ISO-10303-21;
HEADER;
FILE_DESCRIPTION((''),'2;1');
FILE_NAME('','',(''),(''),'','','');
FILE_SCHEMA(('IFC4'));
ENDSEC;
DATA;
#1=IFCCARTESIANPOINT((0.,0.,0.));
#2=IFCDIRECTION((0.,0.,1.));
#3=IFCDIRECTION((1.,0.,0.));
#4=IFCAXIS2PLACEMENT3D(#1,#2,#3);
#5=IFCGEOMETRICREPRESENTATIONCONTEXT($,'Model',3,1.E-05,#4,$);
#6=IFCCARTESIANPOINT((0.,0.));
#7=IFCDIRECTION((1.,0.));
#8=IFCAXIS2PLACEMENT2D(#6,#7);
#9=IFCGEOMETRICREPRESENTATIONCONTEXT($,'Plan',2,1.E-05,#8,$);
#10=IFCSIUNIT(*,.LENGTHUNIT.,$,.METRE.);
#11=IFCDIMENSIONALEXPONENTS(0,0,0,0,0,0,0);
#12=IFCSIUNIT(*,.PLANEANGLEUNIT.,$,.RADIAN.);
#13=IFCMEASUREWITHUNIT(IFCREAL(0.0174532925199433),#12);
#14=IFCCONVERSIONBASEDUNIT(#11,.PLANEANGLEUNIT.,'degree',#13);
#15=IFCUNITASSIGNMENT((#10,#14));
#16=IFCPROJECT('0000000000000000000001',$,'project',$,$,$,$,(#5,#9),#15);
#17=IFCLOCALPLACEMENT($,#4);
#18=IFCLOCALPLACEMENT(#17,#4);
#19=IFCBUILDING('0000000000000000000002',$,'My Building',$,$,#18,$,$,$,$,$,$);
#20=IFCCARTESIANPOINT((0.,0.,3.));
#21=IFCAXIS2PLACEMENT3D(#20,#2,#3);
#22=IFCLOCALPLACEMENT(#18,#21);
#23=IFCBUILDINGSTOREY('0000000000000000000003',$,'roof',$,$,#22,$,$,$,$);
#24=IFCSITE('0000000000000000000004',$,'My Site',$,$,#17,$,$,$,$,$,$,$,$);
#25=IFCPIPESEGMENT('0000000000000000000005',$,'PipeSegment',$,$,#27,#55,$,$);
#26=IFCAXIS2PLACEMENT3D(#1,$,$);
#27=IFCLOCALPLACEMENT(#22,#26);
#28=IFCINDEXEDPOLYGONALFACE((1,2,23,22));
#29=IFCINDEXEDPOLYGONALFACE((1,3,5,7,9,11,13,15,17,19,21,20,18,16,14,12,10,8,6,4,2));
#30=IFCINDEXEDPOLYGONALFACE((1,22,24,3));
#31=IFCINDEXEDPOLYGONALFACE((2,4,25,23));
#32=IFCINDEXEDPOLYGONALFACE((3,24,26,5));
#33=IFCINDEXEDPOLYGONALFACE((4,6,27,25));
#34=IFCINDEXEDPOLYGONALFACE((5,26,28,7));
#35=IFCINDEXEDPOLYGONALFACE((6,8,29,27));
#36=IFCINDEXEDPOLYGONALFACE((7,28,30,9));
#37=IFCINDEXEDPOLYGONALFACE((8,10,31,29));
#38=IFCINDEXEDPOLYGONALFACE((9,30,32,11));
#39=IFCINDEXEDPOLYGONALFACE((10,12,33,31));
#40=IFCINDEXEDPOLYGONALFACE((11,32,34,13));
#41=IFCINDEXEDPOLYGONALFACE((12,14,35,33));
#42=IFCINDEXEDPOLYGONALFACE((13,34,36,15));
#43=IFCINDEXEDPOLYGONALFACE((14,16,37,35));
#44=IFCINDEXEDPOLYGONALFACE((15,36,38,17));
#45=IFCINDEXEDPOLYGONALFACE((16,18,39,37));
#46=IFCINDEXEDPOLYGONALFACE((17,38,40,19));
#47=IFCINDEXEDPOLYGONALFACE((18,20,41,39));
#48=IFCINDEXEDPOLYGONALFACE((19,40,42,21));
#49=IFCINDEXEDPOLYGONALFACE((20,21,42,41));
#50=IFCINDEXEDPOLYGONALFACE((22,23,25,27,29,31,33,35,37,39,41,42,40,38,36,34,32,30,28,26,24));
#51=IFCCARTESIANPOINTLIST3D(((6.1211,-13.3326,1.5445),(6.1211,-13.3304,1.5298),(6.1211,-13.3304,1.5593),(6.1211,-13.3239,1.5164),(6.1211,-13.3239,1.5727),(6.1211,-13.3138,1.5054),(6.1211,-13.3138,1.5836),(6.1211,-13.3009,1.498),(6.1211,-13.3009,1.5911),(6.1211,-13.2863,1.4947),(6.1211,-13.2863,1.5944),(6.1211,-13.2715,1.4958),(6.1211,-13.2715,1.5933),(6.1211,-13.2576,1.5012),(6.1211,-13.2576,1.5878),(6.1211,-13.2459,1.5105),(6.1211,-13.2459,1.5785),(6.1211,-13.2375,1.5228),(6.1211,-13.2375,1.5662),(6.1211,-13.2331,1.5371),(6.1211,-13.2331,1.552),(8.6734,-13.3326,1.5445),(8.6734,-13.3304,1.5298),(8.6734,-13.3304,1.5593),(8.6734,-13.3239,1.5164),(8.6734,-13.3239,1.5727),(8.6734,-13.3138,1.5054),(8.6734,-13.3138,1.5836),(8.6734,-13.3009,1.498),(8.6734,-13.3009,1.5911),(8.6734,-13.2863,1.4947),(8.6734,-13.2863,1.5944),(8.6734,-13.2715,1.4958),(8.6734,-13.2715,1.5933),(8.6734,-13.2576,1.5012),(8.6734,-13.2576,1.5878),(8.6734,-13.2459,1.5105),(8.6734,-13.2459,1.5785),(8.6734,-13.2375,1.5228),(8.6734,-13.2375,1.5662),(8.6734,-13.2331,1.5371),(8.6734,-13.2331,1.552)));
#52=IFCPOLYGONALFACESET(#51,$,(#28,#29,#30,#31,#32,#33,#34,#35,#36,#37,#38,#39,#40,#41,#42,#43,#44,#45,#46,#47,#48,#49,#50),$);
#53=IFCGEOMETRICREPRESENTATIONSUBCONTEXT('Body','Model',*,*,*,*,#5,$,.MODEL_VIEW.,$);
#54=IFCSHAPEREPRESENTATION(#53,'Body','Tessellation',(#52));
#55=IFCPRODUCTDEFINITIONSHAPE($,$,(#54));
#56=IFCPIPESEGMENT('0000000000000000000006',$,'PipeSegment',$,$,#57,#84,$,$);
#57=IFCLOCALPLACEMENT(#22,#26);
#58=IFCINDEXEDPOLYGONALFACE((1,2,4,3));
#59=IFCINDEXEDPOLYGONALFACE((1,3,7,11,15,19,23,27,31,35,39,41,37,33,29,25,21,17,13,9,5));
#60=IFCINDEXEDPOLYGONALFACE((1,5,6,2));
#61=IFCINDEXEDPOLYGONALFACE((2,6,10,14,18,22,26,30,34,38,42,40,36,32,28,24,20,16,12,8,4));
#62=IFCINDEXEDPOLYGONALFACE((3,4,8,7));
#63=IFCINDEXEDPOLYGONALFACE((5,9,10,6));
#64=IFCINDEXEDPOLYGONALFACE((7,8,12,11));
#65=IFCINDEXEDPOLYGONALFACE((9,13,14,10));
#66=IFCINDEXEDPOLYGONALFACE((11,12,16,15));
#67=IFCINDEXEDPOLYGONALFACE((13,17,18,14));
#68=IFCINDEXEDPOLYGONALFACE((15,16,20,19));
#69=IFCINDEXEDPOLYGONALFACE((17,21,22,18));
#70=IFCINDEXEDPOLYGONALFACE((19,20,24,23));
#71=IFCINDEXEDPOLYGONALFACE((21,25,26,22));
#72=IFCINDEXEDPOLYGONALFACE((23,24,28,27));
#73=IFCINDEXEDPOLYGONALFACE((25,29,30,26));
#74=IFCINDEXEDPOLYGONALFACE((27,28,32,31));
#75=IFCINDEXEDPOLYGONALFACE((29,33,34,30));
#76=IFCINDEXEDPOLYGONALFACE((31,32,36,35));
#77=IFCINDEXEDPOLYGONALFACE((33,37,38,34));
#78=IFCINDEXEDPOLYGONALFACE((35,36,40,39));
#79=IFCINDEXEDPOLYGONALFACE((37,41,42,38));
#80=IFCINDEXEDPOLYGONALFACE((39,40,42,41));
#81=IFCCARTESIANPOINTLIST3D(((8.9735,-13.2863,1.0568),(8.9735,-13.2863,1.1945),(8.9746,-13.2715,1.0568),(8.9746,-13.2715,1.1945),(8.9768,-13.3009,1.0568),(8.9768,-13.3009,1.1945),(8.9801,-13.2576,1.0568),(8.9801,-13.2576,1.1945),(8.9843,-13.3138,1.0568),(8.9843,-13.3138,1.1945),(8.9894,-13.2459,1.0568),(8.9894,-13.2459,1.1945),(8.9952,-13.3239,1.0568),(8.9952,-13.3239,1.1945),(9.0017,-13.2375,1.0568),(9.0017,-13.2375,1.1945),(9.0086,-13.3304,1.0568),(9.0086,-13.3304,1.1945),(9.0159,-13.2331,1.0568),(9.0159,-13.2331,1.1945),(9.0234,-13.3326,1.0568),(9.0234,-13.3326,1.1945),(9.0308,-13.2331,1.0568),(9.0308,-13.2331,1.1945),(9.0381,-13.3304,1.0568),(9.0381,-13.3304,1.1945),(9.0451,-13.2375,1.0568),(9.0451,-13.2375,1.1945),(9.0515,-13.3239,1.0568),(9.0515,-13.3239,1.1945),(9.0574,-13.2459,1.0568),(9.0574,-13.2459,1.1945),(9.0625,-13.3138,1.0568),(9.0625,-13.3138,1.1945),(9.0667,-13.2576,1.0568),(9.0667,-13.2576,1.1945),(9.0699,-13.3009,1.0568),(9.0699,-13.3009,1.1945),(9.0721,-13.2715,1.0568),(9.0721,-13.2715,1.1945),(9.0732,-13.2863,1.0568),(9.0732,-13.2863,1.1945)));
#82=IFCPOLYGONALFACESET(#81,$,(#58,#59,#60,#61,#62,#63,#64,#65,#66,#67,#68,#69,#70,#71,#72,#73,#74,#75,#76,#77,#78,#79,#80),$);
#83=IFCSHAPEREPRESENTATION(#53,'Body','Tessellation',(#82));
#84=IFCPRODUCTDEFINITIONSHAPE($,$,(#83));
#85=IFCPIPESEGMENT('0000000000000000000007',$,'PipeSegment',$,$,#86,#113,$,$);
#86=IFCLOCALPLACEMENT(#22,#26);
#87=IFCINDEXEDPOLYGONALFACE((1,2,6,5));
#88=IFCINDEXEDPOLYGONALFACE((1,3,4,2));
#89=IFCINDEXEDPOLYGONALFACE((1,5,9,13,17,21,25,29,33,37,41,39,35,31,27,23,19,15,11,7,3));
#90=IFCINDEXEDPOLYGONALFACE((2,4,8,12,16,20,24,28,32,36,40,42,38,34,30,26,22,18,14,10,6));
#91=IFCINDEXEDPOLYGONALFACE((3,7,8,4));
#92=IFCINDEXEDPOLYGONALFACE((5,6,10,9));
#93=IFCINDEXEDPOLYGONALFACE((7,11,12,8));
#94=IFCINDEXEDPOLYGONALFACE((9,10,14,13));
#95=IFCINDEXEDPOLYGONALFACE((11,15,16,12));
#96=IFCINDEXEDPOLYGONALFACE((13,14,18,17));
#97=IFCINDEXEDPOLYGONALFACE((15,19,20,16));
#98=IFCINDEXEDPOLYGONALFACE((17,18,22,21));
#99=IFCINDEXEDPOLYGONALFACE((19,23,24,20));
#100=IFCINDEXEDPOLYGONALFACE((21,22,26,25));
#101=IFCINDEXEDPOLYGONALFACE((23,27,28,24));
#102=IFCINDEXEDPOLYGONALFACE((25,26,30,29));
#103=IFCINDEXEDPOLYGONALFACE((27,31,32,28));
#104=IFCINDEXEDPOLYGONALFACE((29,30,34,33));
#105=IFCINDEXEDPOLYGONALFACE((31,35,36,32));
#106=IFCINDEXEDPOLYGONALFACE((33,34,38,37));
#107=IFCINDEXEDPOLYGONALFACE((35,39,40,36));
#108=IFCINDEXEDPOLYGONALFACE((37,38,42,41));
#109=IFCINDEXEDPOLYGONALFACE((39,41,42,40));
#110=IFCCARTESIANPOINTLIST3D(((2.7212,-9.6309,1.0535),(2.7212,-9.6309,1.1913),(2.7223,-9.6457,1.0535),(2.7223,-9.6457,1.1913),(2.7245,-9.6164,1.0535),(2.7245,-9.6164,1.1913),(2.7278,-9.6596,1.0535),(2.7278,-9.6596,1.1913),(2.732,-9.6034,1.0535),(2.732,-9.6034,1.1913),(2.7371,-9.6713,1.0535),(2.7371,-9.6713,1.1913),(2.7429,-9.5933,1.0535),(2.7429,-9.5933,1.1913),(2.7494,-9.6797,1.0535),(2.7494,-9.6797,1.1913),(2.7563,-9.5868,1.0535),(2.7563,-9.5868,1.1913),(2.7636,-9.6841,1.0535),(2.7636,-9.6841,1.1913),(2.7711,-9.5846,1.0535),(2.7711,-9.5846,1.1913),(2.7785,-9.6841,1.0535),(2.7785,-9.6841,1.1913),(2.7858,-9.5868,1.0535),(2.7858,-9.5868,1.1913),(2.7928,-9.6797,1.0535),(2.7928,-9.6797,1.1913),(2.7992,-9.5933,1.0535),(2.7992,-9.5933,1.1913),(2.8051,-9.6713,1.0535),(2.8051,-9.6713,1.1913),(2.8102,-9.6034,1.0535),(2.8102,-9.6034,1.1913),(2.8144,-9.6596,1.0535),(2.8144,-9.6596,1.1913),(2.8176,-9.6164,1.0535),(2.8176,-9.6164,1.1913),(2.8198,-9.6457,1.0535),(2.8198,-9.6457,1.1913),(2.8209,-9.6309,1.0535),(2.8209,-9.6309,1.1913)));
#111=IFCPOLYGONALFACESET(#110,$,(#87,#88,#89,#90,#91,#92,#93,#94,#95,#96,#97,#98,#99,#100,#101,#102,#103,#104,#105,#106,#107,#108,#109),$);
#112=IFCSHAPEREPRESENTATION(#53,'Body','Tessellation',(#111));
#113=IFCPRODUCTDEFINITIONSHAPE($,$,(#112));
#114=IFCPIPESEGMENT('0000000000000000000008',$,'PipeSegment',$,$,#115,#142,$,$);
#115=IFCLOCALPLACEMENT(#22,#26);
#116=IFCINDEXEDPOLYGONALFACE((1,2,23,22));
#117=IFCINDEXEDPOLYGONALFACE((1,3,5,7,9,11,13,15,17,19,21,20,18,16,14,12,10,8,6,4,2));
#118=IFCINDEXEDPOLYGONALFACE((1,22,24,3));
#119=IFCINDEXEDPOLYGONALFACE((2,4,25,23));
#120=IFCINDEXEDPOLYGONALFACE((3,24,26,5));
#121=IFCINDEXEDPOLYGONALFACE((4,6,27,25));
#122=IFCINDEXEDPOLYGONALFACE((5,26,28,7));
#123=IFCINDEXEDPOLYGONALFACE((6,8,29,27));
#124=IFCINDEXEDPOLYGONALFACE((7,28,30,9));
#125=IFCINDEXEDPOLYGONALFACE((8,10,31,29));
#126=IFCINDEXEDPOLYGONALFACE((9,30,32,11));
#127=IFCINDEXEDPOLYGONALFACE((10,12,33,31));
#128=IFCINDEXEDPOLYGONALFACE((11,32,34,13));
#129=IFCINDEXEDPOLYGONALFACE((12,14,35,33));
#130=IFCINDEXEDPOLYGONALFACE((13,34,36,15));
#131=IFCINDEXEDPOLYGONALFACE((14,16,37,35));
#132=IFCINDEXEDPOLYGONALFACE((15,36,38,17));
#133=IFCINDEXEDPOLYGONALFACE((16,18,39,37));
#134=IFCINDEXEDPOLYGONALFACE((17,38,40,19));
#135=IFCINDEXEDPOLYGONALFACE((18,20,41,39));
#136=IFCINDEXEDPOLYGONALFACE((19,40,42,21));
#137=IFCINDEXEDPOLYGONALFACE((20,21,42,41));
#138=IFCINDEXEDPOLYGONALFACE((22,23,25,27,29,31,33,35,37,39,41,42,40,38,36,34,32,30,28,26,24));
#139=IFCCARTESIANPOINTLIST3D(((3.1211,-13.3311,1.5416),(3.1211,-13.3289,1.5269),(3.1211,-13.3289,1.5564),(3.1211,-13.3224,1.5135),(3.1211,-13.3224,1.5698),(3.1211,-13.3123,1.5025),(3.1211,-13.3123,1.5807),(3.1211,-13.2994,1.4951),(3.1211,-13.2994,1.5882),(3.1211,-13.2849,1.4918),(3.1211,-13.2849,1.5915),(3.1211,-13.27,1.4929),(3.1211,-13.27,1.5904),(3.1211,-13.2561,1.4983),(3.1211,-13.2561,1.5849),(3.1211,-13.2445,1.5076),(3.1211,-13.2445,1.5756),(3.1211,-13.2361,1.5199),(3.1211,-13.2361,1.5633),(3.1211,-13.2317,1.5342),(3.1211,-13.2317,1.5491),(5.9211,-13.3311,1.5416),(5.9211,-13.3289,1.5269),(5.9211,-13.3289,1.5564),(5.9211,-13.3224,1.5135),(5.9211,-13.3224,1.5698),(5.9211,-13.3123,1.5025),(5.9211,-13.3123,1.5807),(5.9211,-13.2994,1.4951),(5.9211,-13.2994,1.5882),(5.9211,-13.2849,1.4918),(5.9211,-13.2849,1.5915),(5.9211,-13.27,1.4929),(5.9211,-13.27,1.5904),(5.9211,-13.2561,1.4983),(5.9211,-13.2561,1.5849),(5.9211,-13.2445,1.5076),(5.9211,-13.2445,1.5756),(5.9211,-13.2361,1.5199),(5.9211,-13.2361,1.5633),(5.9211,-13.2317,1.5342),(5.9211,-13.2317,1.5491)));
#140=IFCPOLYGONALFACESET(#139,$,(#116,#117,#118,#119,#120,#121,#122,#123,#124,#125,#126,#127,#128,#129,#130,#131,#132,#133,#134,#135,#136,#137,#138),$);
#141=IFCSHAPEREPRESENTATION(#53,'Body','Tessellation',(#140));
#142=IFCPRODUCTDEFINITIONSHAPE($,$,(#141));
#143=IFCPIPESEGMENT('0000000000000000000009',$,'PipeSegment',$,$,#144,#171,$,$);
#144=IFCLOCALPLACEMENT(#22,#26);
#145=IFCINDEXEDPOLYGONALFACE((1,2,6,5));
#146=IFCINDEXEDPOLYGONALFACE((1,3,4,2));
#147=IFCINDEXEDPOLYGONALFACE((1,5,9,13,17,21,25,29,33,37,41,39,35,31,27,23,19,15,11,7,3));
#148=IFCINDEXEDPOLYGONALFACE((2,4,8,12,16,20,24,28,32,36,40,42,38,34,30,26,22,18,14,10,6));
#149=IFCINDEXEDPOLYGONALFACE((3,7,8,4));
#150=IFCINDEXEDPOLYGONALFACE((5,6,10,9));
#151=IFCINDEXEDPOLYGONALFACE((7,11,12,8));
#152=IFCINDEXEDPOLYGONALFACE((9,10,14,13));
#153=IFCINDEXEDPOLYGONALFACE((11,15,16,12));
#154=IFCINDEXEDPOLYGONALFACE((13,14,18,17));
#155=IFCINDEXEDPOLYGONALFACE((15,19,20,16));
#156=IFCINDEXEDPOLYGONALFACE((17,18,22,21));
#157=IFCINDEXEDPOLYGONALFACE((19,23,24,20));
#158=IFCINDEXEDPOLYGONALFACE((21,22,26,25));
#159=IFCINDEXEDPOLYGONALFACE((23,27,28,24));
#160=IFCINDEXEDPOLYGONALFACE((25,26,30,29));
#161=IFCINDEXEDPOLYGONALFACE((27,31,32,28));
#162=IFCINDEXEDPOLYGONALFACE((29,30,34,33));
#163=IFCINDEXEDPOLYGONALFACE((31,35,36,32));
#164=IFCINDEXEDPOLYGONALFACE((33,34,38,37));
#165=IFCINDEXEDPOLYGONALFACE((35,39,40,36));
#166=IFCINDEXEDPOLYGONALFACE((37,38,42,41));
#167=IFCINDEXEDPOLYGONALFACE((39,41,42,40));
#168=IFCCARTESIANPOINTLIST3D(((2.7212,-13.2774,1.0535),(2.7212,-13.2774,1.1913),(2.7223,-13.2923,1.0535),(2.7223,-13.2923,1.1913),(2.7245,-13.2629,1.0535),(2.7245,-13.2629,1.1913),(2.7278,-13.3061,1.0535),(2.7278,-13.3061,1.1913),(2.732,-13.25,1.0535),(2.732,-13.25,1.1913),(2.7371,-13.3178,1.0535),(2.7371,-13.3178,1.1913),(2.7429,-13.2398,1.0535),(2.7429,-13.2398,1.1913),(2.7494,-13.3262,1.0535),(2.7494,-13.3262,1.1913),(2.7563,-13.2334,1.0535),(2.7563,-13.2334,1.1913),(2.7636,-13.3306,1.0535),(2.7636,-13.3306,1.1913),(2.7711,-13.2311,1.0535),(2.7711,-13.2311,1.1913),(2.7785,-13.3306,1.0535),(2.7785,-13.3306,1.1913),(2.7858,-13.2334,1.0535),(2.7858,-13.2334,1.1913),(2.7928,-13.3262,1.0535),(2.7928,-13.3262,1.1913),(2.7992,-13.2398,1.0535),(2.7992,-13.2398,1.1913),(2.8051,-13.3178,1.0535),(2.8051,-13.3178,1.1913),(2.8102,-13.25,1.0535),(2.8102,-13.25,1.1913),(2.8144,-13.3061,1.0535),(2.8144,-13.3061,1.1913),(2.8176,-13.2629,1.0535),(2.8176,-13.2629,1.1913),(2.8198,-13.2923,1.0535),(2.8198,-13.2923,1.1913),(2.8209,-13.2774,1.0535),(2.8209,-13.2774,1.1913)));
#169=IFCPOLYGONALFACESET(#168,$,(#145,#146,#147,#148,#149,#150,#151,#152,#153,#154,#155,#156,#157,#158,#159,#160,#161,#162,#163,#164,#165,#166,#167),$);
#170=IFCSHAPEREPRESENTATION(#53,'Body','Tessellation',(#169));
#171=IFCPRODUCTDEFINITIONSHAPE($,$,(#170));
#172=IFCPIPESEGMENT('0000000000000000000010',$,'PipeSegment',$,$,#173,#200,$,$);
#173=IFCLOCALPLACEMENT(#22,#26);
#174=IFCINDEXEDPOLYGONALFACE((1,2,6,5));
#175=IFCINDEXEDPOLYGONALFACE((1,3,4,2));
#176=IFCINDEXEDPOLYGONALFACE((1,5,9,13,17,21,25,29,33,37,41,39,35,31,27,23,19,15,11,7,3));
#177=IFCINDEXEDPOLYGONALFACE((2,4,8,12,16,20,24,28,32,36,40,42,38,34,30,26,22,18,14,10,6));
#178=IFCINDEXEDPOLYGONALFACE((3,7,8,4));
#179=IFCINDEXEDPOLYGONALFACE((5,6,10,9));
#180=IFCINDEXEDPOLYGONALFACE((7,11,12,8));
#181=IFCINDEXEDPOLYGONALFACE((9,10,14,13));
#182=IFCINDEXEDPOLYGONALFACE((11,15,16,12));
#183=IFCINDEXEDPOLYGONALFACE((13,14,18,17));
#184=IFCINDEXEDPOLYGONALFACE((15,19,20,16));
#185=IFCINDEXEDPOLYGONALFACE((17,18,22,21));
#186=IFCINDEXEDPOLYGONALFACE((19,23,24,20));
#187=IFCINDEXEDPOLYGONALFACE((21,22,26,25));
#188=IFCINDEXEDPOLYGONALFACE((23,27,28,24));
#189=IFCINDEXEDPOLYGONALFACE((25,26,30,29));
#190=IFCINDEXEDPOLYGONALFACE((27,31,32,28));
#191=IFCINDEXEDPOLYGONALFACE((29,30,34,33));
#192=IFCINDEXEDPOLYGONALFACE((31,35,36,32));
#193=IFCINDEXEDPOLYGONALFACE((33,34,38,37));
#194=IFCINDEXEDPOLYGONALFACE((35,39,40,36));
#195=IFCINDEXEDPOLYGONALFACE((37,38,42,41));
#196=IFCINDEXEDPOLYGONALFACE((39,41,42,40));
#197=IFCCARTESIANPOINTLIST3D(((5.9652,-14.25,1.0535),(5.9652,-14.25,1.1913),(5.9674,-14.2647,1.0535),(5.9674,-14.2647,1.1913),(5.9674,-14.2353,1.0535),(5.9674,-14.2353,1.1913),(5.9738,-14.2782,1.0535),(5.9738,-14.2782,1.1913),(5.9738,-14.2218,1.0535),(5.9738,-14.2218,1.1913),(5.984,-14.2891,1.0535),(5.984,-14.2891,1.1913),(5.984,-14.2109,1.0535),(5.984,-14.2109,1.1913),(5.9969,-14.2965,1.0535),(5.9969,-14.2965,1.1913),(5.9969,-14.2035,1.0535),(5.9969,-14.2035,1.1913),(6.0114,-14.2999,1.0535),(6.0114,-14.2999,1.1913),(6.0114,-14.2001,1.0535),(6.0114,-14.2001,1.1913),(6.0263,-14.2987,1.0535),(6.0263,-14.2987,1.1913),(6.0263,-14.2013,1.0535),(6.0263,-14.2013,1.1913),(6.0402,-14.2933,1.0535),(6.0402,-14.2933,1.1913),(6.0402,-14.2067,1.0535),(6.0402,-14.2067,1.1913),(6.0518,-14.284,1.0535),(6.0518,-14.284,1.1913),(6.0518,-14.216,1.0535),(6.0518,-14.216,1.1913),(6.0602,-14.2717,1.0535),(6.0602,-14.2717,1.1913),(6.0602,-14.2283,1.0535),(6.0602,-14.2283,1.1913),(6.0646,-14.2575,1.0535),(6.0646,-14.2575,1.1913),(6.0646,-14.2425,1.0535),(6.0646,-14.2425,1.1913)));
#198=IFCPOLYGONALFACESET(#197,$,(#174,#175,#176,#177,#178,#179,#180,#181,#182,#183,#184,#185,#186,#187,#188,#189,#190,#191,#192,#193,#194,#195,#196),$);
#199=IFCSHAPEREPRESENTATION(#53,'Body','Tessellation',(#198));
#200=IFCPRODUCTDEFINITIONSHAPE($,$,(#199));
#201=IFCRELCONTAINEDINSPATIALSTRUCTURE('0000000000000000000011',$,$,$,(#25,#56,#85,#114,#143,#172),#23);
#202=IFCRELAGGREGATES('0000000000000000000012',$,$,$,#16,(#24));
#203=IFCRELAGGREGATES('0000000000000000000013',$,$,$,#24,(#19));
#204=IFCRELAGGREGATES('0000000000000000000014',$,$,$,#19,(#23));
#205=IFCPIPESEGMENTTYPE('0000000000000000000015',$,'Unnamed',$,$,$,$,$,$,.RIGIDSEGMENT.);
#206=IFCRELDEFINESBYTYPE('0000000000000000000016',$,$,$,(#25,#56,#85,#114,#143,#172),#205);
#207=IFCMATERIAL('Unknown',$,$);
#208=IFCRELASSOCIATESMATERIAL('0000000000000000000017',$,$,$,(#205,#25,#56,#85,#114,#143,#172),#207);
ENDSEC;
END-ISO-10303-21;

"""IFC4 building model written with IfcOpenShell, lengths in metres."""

from ifc_helpers import new_model, entity, si_unit, converted_unit, frame, origin_with_axes, origin_2d_with_axis, place, context, subcontext, project, spatial, circle, extrude, material, material_profile, profile_set, profile_usage, type_object, element, save


model = new_model("IFC4")

# Units and contexts
model_context = context("Model", 3, precision=1e-05, world=origin_with_axes())
plan_context = context("Plan", 2, precision=1e-05, world=origin_2d_with_axis())
body_context_1 = subcontext(model_context, "Body", "Model", "MODEL_VIEW")
ifc_project = project(units=[si_unit("LENGTHUNIT", "METRE"), converted_unit("PLANEANGLEUNIT", "degree", entity("IfcReal", 0.0174532925199433), si_unit("PLANEANGLEUNIT", "RADIAN"), dimensions=[0, 0, 0, 0, 0, 0, 0])], contexts=[model_context, plan_context])

# Site, building, storey
site_placement = place(None, origin_with_axes())
site = spatial("IfcSite", under=ifc_project, at=site_placement, Name="My Site")
building_placement = place(site_placement, origin_with_axes())
building = spatial("IfcBuilding", under=site, at=building_placement, Name="My Building")
storey_placement = place(building_placement, frame((0.0, 0.0, 3.0), z_axis=(0.0, 0.0, 1.0), x_axis=(1.0, 0.0, 0.0)))
storey = spatial("IfcBuildingStorey", under=building, at=storey_placement, Name="roof")

# Shared definitions
ifc_material = material(Name="Unknown")

# Pipe segments
ifc_material_profile_1 = material_profile(ifc_material, circle(Radius=0.05))
ifc_profile_set_1 = profile_set([ifc_material_profile_1])
pipe_segment_type = type_object("IfcPipeSegmentType", Name="Unnamed", PredefinedType="RIGIDSEGMENT", material=ifc_profile_set_1)
ifc_profile_usage_1 = profile_usage(ifc_profile_set_1, cardinal=5)
pipe_segment_1_placement = place(storey_placement, frame((6.1211, -13.2826, 1.5445), z_axis=(1.0, 0.0, 0.0), x_axis=(0.0, -1.0, 0.0)))
element("IfcPipeSegment", 1, at=pipe_segment_1_placement, inside=storey, type_object=pipe_segment_type, material=ifc_profile_usage_1, Name="PipeSegment", context=body_context_1, shape_type="SweptSolid", body=[
    extrude(circle(Radius=0.05), origin_with_axes(), (0.0, 0.0, 1.0), 2.5523),
])
ifc_profile_usage_2 = profile_usage(ifc_profile_set_1, cardinal=5)
pipe_segment_2_placement = place(storey_placement, frame((9.0234, -13.2826, 1.0568), z_axis=(0.000001, -0.000001, 1.0), x_axis=(0.0, -1.0, -0.000001)))
element("IfcPipeSegment", 2, at=pipe_segment_2_placement, inside=storey, type_object=pipe_segment_type, material=ifc_profile_usage_2, Name="PipeSegment", context=body_context_1, shape_type="SweptSolid", body=[
    extrude(circle(Radius=0.05), origin_with_axes(), (0.0, 0.0, 1.0), 0.1377),
])
ifc_profile_usage_3 = profile_usage(ifc_profile_set_1, cardinal=5)
pipe_segment_3_placement = place(storey_placement, frame((2.7711, -9.6346, 1.0535), z_axis=(-0.000001, 0.000001, 1.0), x_axis=(0.0, 1.0, -0.000001)))
element("IfcPipeSegment", 3, at=pipe_segment_3_placement, inside=storey, type_object=pipe_segment_type, material=ifc_profile_usage_3, Name="PipeSegment", context=body_context_1, shape_type="SweptSolid", body=[
    extrude(circle(Radius=0.05), origin_with_axes(), (0.0, 0.0, 1.0), 0.1377),
])
ifc_profile_usage_4 = profile_usage(ifc_profile_set_1, cardinal=5)
pipe_segment_4_placement = place(storey_placement, frame((5.9211, -13.2811, 1.5416), z_axis=(-1.0, 0.0, 0.0), x_axis=(0.0, -1.0, 0.0)))
element("IfcPipeSegment", 4, at=pipe_segment_4_placement, inside=storey, type_object=pipe_segment_type, material=ifc_profile_usage_4, Name="PipeSegment", context=body_context_1, shape_type="SweptSolid", body=[
    extrude(circle(Radius=0.05), origin_with_axes(), (0.0, 0.0, 1.0), 2.8),
])
ifc_profile_usage_5 = profile_usage(ifc_profile_set_1, cardinal=5)
pipe_segment_5_placement = place(storey_placement, frame((2.7711, -13.2811, 1.0535), z_axis=(-0.000001, 0.000001, 1.0), x_axis=(0.0, 1.0, -0.000001)))
element("IfcPipeSegment", 5, at=pipe_segment_5_placement, inside=storey, type_object=pipe_segment_type, material=ifc_profile_usage_5, Name="PipeSegment", context=body_context_1, shape_type="SweptSolid", body=[
    extrude(circle(Radius=0.05), origin_with_axes(), (0.0, 0.0, 1.0), 0.1377),
])
ifc_profile_usage_6 = profile_usage(ifc_profile_set_1, cardinal=5)
pipe_segment_6_placement = place(storey_placement, frame((6.0152, -14.25, 1.0535), z_axis=(-0.000001, -0.000001, 1.0), x_axis=(-1.0, 0.0, -0.000001)))
element("IfcPipeSegment", 6, at=pipe_segment_6_placement, inside=storey, type_object=pipe_segment_type, material=ifc_profile_usage_6, Name="PipeSegment", context=body_context_1, shape_type="SweptSolid", body=[
    extrude(circle(Radius=0.05), origin_with_axes(), (0.0, 0.0, 1.0), 0.1377),
])

save(model, "model.ifc")
